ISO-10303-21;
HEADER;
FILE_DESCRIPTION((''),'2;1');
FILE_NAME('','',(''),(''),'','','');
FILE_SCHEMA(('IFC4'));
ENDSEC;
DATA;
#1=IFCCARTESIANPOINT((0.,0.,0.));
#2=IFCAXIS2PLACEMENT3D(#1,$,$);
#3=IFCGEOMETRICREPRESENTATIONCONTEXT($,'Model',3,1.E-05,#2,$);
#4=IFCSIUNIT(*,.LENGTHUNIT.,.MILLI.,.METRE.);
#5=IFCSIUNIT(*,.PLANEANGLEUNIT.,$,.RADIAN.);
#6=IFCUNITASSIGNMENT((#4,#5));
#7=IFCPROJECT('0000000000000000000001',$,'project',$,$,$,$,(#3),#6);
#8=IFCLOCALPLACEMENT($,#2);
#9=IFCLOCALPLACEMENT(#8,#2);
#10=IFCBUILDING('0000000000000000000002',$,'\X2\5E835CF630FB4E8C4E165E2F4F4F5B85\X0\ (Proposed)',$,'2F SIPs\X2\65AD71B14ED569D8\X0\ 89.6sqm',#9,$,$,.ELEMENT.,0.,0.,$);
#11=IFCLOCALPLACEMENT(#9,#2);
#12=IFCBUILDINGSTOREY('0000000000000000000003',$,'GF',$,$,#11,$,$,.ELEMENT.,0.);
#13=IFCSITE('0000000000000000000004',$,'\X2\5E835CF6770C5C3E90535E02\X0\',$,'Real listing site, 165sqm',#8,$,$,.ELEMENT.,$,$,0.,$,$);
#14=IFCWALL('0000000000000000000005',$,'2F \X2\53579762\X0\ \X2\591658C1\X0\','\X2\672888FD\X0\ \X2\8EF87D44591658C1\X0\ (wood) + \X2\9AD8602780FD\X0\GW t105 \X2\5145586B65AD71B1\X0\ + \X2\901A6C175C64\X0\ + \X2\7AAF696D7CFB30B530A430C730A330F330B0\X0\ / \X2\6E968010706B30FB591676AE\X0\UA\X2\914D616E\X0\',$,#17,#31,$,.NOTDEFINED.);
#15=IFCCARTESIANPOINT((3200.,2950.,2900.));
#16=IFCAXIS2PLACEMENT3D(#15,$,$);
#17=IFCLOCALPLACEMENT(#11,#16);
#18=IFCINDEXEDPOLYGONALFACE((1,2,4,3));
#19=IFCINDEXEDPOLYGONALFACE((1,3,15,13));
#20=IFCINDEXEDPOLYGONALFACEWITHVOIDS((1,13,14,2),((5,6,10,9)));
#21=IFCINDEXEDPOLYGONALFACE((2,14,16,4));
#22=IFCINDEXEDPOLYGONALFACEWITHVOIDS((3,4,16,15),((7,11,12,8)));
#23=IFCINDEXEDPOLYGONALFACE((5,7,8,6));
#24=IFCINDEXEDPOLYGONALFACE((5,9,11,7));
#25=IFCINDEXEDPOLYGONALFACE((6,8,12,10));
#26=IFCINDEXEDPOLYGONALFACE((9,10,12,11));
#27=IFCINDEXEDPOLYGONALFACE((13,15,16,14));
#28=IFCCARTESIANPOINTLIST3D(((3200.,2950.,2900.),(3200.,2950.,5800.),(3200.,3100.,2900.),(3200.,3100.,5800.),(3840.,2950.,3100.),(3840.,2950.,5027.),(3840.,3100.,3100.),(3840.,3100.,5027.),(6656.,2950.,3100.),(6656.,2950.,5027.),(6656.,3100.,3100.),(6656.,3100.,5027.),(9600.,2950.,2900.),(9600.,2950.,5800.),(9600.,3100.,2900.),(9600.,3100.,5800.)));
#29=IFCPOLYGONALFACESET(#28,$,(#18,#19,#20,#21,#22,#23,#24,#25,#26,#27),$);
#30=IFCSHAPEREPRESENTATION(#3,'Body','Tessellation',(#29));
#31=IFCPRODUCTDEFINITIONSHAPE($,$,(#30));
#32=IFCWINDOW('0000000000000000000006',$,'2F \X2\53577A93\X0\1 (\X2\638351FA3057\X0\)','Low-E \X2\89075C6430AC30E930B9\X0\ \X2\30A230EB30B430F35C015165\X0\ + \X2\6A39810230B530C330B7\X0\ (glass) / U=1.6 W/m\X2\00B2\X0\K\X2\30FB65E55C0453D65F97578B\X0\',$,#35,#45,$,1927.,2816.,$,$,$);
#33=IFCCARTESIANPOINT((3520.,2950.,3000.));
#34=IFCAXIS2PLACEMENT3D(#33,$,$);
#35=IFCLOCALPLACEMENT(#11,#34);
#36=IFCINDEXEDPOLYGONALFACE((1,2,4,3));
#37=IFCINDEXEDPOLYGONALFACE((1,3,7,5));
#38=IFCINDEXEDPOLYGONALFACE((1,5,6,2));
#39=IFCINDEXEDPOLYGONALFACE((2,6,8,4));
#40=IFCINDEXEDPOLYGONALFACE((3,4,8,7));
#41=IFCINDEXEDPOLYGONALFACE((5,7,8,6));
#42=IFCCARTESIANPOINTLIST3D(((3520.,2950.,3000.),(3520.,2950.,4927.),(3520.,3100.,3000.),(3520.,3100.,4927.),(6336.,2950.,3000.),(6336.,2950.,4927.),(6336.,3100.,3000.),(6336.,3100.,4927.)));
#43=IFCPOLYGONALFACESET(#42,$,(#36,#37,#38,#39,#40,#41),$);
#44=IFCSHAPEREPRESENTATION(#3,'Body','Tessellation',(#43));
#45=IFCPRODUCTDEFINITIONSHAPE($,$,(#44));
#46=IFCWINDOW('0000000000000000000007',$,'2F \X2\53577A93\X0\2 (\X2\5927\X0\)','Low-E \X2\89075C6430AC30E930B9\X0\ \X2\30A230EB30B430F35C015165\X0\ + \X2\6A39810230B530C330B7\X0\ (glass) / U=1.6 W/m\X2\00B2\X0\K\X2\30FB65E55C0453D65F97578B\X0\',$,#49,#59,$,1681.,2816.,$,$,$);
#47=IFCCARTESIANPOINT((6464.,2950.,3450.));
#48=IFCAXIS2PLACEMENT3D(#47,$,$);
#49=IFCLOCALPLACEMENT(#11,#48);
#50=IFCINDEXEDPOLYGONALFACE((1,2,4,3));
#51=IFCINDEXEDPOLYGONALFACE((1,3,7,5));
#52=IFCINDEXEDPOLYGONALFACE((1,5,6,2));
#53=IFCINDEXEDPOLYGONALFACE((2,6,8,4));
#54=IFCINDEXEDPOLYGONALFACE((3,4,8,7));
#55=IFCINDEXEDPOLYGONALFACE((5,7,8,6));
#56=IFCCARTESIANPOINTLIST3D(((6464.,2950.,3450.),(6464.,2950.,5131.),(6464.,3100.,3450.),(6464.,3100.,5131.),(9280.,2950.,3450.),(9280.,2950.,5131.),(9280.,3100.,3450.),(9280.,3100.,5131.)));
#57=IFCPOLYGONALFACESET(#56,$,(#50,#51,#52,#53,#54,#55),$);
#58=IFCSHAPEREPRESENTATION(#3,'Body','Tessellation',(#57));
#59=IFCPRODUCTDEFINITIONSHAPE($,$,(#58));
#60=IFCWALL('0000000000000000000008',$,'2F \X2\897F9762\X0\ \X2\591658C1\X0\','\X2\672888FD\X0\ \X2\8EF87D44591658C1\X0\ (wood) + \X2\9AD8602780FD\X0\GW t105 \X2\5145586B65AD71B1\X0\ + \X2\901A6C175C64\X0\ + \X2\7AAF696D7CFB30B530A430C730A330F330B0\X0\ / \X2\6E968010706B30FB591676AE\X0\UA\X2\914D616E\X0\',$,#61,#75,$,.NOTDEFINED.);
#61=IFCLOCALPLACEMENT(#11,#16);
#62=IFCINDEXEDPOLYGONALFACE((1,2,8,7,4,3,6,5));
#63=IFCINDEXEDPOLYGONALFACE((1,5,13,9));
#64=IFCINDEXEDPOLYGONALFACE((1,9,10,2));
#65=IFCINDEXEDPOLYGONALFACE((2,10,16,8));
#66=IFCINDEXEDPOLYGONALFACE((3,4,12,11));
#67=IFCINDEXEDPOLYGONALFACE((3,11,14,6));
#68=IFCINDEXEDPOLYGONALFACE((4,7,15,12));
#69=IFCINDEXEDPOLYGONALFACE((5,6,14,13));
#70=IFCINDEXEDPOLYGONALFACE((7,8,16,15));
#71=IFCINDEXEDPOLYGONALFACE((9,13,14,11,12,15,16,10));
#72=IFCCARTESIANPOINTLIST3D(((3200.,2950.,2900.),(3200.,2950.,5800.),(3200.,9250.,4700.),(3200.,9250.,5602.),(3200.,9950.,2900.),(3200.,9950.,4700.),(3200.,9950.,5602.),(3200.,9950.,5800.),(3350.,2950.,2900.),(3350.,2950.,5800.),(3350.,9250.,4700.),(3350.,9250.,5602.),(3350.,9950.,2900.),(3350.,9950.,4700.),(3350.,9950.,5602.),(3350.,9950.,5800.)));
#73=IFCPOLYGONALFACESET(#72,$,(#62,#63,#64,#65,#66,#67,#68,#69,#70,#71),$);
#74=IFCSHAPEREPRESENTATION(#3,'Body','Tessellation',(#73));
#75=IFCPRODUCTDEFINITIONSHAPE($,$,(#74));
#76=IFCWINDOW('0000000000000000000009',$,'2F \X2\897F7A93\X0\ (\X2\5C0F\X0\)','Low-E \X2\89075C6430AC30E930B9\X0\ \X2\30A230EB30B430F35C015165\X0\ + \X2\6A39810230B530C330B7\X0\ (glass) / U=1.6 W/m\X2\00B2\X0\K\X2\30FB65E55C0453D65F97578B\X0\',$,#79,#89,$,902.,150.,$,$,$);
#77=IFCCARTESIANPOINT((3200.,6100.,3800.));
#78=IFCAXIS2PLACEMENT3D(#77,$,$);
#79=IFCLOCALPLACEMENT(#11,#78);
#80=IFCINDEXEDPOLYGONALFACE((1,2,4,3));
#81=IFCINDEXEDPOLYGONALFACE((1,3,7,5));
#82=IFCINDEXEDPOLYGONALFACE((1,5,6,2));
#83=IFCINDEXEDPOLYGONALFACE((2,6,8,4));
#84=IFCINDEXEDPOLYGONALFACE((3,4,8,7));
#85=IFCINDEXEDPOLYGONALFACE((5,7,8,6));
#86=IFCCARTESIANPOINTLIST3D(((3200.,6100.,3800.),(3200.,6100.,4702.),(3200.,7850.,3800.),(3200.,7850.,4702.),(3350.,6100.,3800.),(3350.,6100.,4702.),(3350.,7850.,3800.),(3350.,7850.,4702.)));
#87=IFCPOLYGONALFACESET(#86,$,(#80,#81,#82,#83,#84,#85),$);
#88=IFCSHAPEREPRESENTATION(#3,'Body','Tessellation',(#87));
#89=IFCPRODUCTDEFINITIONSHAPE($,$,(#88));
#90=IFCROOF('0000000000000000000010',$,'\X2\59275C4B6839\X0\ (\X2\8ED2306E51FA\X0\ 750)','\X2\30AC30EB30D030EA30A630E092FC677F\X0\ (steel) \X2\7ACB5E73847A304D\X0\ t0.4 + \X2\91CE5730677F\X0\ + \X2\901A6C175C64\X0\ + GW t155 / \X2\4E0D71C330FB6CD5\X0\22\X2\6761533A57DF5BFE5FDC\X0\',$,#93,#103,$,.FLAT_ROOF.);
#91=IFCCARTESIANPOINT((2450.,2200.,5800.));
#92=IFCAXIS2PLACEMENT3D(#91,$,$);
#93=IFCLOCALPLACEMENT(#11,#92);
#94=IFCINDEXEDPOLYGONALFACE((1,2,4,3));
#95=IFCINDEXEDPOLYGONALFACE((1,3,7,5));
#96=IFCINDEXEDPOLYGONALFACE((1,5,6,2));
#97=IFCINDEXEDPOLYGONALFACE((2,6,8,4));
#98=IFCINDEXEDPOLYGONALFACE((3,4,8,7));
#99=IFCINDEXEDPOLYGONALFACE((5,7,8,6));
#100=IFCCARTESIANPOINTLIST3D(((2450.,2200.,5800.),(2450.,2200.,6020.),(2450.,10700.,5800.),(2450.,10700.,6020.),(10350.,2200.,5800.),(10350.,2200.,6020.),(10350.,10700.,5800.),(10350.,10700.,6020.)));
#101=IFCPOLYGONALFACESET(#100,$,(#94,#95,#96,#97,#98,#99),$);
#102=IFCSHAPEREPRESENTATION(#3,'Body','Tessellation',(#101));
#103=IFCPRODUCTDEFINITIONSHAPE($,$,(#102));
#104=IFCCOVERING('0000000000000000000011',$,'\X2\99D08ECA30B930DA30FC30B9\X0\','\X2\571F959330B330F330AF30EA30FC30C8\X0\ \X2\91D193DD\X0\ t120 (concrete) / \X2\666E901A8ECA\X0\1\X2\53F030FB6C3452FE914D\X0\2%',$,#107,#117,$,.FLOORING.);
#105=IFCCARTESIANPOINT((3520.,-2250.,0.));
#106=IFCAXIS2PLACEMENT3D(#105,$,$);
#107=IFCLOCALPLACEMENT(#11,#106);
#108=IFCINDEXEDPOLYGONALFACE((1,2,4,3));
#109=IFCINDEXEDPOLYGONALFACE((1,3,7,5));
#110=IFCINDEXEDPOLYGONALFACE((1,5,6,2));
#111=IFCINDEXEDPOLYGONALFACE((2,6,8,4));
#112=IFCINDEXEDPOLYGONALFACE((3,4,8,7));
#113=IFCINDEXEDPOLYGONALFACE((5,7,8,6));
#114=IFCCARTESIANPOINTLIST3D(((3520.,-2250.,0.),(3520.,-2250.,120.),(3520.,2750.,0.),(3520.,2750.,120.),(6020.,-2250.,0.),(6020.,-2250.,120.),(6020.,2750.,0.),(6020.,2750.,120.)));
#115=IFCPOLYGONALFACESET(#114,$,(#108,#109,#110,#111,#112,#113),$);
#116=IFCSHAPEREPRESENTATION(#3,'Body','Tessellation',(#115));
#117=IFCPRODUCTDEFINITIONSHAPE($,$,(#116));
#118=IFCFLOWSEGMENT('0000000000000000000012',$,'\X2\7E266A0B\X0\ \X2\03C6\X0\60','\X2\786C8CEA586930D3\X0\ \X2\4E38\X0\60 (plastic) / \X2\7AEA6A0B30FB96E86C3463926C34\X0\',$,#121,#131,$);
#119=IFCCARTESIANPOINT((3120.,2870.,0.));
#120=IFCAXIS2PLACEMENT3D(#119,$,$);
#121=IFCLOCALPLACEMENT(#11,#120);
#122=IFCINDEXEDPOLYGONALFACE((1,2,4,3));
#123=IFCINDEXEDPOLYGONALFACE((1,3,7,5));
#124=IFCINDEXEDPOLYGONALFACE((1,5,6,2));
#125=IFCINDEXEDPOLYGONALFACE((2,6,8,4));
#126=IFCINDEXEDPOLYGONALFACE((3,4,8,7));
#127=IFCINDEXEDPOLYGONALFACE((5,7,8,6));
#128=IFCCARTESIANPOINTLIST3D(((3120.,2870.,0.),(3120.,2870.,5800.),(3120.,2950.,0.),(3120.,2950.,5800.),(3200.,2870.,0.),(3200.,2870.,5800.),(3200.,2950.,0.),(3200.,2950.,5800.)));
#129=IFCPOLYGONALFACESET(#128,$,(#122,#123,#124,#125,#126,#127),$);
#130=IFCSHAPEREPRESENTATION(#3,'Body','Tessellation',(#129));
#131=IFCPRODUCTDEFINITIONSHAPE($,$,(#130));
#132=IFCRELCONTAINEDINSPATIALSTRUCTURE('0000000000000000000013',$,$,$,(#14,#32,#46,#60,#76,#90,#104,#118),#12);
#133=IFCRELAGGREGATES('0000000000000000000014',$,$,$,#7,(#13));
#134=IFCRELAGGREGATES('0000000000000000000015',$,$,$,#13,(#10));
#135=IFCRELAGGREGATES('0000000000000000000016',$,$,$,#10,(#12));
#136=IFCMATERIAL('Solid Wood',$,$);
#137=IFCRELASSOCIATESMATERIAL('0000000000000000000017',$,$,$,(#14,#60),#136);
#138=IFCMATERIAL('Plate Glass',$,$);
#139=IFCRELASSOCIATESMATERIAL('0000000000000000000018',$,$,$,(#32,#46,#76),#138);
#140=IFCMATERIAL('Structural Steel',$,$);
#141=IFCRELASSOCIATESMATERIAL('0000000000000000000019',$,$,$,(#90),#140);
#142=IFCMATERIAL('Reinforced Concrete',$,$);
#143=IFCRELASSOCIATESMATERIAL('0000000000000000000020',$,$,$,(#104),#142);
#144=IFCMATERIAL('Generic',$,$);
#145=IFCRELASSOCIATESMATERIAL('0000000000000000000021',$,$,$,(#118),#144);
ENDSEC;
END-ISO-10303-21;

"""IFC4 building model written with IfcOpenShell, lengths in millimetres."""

from ifc_helpers import new_model, si_unit, frame, frame_2d, origin, place, context, project, spatial, rectangle, extrude, material, element, fill, save


model = new_model("IFC4")

# Units and contexts
model_context = context("Model", 3, precision=1e-05, world=origin())
ifc_project = project(units=[si_unit("LENGTHUNIT", "METRE", prefix="MILLI"), si_unit("PLANEANGLEUNIT", "RADIAN")], contexts=[model_context])

# Site, building, storey
site_placement = place(None, origin())
site = spatial("IfcSite", under=ifc_project, at=site_placement, Name="広島県尾道市", ObjectType="Real listing site, 165sqm", CompositionType="ELEMENT", RefElevation=0.0)
building_placement = place(site_placement, origin())
building = spatial("IfcBuilding", under=site, at=building_placement, Name="広島・二世帯住宅 (Proposed)", ObjectType="2F SIPs断熱仕様 89.6sqm", CompositionType="ELEMENT", ElevationOfRefHeight=0.0, ElevationOfTerrain=0.0)
storey_placement = place(building_placement, origin())
storey = spatial("IfcBuildingStorey", under=building, at=storey_placement, Name="GF", CompositionType="ELEMENT", Elevation=0.0)

# Shared definitions
ifc_material_1 = material(Name="Solid Wood")

# Shared definitions
ifc_material_2 = material(Name="Reinforced Concrete")

# Shared definitions
ifc_material_3 = material(Name="Plate Glass")

# Wall, openings, windows
wall_1_placement = place(storey_placement, frame((3200.0, 2950.0, 2900.0)))
wall_1 = element("IfcWall", 1, at=wall_1_placement, inside=storey, material=ifc_material_1, Name="2F 南面 外壁", Description="木製 軸組外壁 (wood) + 高性能GW t105 充填断熱 + 通気層 + 窯業系サイディング / 準耐火・外皮UA配慮", PredefinedType="NOTDEFINED", context=model_context, shape_type="SweptSolid", body=[
    extrude(rectangle(XDim=6400.0, YDim=150.0, at=frame_2d((3200.0, 75.0))), frame((3200.0, 2950.0, 2900.0)), (0.0, 0.0, 1.0), 2900.0),
])
opening_1_placement = place(storey_placement, frame((3520.0, 2950.0, 3000.0)))
opening_1 = element("IfcOpeningElement", 2, at=opening_1_placement, cuts=wall_1, PredefinedType="NOTDEFINED", context=model_context, shape_type="SweptSolid", body=[
    extrude(rectangle(XDim=2816.0, YDim=150.0, at=frame_2d((1408.0, 75.0))), frame((3520.0, 2950.0, 3000.0)), (0.0, 0.0, 1.0), 1927.0),
])
opening_2_placement = place(storey_placement, frame((6464.0, 2950.0, 3450.0)))
opening_2 = element("IfcOpeningElement", 3, at=opening_2_placement, cuts=wall_1, PredefinedType="NOTDEFINED", context=model_context, shape_type="SweptSolid", body=[
    extrude(rectangle(XDim=2816.0, YDim=150.0, at=frame_2d((1408.0, 75.0))), frame((6464.0, 2950.0, 3450.0)), (0.0, 0.0, 1.0), 1681.0),
])
window_1_placement = place(storey_placement, frame((3520.0, 2950.0, 3000.0)))
window_1 = element("IfcWindow", 4, at=window_1_placement, inside=storey, material=ifc_material_3, Name="2F 南窓1 (掃出し)", Description="Low-E 複層ガラス アルゴン封入 + 樹脂サッシ (glass) / U=1.6 W/m²K・日射取得型", OverallHeight=1927.0, OverallWidth=2816.0, context=model_context, shape_type="SweptSolid", body=[
    extrude(rectangle(XDim=2816.0, YDim=150.0, at=frame_2d((1408.0, 75.0))), frame((3520.0, 2950.0, 3000.0)), (0.0, 0.0, 1.0), 1927.0),
])
fill(opening_1, window_1)
window_2_placement = place(storey_placement, frame((6464.0, 2950.0, 3450.0)))
window_2 = element("IfcWindow", 5, at=window_2_placement, inside=storey, material=ifc_material_3, Name="2F 南窓2 (大)", Description="Low-E 複層ガラス アルゴン封入 + 樹脂サッシ (glass) / U=1.6 W/m²K・日射取得型", OverallHeight=1681.0, OverallWidth=2816.0, context=model_context, shape_type="SweptSolid", body=[
    extrude(rectangle(XDim=2816.0, YDim=150.0, at=frame_2d((1408.0, 75.0))), frame((6464.0, 2950.0, 3450.0)), (0.0, 0.0, 1.0), 1681.0),
])
fill(opening_2, window_2)

# Wall, opening, window
wall_2_placement = place(storey_placement, frame((3200.0, 2950.0, 2900.0)))
wall_2 = element("IfcWall", 6, at=wall_2_placement, inside=storey, material=ifc_material_1, Name="2F 西面 外壁", Description="木製 軸組外壁 (wood) + 高性能GW t105 充填断熱 + 通気層 + 窯業系サイディング / 準耐火・外皮UA配慮", PredefinedType="NOTDEFINED", context=model_context, shape_type="SweptSolid", body=[
    extrude(rectangle(XDim=150.0, YDim=7000.0, at=frame_2d((75.0, 3500.0))), frame((3200.0, 2950.0, 2900.0)), (0.0, 0.0, 1.0), 2900.0),
])
opening_3_placement = place(storey_placement, frame((3200.0, 6100.0, 3800.0)))
opening_3 = element("IfcOpeningElement", 7, at=opening_3_placement, cuts=wall_2, PredefinedType="NOTDEFINED", context=model_context, shape_type="SweptSolid", body=[
    extrude(rectangle(XDim=150.0, YDim=1750.0, at=frame_2d((75.0, 875.0))), frame((3200.0, 6100.0, 3800.0)), (0.0, 0.0, 1.0), 902.0),
])
window_3_placement = place(storey_placement, frame((3200.0, 6100.0, 3800.0)))
window_3 = element("IfcWindow", 8, at=window_3_placement, inside=storey, material=ifc_material_3, Name="2F 西窓 (小)", Description="Low-E 複層ガラス アルゴン封入 + 樹脂サッシ (glass) / U=1.6 W/m²K・日射取得型", OverallHeight=902.0, OverallWidth=150.0, context=model_context, shape_type="SweptSolid", body=[
    extrude(rectangle(XDim=150.0, YDim=1750.0, at=frame_2d((75.0, 875.0))), frame((3200.0, 6100.0, 3800.0)), (0.0, 0.0, 1.0), 902.0),
])
fill(opening_3, window_3)

# Roof
ifc_material_4 = material(Name="Structural Steel")
roof_placement = place(storey_placement, frame((2450.0, 2200.0, 5800.0)))
element("IfcRoof", 9, at=roof_placement, inside=storey, material=ifc_material_4, Name="大屋根 (軒の出 750)", Description="ガルバリウム鋼板 (steel) 立平葺き t0.4 + 野地板 + 通気層 + GW t155 / 不燃・法22条区域対応", PredefinedType="FLAT_ROOF", context=model_context, shape_type="SweptSolid", body=[
    extrude(rectangle(XDim=7900.0, YDim=8500.0, at=frame_2d((3950.0, 4250.0))), frame((2450.0, 2200.0, 5800.0)), (0.0, 0.0, 1.0), 220.0),
])

# Covering
covering_placement = place(storey_placement, frame((3520.0, -2250.0, 0.0)))
element("IfcCovering", 10, at=covering_placement, inside=storey, material=ifc_material_2, Name="駐車スペース", Description="土間コンクリート 金鏝 t120 (concrete) / 普通車1台・水勾配2%", PredefinedType="FLOORING", context=model_context, shape_type="SweptSolid", body=[
    extrude(rectangle(XDim=2500.0, YDim=5000.0, at=frame_2d((1250.0, 2500.0))), frame((3520.0, -2250.0, 0.0)), (0.0, 0.0, 1.0), 120.0),
])

# Flow segment
ifc_material_5 = material(Name="Generic")
flow_segment_1_placement = place(storey_placement, frame((3120.0, 2870.0, 0.0)))
element("IfcFlowSegment", 11, at=flow_segment_1_placement, inside=storey, material=ifc_material_5, Name="縦樋 φ60", Description="硬質塩ビ 丸60 (plastic) / 竪樋・雨水排水", context=model_context, shape_type="SweptSolid", body=[
    extrude(rectangle(XDim=80.0, YDim=80.0, at=frame_2d((40.0, 40.0))), frame((3120.0, 2870.0, 0.0)), (0.0, 0.0, 1.0), 5800.0),
])

save(model, "model.ifc")
